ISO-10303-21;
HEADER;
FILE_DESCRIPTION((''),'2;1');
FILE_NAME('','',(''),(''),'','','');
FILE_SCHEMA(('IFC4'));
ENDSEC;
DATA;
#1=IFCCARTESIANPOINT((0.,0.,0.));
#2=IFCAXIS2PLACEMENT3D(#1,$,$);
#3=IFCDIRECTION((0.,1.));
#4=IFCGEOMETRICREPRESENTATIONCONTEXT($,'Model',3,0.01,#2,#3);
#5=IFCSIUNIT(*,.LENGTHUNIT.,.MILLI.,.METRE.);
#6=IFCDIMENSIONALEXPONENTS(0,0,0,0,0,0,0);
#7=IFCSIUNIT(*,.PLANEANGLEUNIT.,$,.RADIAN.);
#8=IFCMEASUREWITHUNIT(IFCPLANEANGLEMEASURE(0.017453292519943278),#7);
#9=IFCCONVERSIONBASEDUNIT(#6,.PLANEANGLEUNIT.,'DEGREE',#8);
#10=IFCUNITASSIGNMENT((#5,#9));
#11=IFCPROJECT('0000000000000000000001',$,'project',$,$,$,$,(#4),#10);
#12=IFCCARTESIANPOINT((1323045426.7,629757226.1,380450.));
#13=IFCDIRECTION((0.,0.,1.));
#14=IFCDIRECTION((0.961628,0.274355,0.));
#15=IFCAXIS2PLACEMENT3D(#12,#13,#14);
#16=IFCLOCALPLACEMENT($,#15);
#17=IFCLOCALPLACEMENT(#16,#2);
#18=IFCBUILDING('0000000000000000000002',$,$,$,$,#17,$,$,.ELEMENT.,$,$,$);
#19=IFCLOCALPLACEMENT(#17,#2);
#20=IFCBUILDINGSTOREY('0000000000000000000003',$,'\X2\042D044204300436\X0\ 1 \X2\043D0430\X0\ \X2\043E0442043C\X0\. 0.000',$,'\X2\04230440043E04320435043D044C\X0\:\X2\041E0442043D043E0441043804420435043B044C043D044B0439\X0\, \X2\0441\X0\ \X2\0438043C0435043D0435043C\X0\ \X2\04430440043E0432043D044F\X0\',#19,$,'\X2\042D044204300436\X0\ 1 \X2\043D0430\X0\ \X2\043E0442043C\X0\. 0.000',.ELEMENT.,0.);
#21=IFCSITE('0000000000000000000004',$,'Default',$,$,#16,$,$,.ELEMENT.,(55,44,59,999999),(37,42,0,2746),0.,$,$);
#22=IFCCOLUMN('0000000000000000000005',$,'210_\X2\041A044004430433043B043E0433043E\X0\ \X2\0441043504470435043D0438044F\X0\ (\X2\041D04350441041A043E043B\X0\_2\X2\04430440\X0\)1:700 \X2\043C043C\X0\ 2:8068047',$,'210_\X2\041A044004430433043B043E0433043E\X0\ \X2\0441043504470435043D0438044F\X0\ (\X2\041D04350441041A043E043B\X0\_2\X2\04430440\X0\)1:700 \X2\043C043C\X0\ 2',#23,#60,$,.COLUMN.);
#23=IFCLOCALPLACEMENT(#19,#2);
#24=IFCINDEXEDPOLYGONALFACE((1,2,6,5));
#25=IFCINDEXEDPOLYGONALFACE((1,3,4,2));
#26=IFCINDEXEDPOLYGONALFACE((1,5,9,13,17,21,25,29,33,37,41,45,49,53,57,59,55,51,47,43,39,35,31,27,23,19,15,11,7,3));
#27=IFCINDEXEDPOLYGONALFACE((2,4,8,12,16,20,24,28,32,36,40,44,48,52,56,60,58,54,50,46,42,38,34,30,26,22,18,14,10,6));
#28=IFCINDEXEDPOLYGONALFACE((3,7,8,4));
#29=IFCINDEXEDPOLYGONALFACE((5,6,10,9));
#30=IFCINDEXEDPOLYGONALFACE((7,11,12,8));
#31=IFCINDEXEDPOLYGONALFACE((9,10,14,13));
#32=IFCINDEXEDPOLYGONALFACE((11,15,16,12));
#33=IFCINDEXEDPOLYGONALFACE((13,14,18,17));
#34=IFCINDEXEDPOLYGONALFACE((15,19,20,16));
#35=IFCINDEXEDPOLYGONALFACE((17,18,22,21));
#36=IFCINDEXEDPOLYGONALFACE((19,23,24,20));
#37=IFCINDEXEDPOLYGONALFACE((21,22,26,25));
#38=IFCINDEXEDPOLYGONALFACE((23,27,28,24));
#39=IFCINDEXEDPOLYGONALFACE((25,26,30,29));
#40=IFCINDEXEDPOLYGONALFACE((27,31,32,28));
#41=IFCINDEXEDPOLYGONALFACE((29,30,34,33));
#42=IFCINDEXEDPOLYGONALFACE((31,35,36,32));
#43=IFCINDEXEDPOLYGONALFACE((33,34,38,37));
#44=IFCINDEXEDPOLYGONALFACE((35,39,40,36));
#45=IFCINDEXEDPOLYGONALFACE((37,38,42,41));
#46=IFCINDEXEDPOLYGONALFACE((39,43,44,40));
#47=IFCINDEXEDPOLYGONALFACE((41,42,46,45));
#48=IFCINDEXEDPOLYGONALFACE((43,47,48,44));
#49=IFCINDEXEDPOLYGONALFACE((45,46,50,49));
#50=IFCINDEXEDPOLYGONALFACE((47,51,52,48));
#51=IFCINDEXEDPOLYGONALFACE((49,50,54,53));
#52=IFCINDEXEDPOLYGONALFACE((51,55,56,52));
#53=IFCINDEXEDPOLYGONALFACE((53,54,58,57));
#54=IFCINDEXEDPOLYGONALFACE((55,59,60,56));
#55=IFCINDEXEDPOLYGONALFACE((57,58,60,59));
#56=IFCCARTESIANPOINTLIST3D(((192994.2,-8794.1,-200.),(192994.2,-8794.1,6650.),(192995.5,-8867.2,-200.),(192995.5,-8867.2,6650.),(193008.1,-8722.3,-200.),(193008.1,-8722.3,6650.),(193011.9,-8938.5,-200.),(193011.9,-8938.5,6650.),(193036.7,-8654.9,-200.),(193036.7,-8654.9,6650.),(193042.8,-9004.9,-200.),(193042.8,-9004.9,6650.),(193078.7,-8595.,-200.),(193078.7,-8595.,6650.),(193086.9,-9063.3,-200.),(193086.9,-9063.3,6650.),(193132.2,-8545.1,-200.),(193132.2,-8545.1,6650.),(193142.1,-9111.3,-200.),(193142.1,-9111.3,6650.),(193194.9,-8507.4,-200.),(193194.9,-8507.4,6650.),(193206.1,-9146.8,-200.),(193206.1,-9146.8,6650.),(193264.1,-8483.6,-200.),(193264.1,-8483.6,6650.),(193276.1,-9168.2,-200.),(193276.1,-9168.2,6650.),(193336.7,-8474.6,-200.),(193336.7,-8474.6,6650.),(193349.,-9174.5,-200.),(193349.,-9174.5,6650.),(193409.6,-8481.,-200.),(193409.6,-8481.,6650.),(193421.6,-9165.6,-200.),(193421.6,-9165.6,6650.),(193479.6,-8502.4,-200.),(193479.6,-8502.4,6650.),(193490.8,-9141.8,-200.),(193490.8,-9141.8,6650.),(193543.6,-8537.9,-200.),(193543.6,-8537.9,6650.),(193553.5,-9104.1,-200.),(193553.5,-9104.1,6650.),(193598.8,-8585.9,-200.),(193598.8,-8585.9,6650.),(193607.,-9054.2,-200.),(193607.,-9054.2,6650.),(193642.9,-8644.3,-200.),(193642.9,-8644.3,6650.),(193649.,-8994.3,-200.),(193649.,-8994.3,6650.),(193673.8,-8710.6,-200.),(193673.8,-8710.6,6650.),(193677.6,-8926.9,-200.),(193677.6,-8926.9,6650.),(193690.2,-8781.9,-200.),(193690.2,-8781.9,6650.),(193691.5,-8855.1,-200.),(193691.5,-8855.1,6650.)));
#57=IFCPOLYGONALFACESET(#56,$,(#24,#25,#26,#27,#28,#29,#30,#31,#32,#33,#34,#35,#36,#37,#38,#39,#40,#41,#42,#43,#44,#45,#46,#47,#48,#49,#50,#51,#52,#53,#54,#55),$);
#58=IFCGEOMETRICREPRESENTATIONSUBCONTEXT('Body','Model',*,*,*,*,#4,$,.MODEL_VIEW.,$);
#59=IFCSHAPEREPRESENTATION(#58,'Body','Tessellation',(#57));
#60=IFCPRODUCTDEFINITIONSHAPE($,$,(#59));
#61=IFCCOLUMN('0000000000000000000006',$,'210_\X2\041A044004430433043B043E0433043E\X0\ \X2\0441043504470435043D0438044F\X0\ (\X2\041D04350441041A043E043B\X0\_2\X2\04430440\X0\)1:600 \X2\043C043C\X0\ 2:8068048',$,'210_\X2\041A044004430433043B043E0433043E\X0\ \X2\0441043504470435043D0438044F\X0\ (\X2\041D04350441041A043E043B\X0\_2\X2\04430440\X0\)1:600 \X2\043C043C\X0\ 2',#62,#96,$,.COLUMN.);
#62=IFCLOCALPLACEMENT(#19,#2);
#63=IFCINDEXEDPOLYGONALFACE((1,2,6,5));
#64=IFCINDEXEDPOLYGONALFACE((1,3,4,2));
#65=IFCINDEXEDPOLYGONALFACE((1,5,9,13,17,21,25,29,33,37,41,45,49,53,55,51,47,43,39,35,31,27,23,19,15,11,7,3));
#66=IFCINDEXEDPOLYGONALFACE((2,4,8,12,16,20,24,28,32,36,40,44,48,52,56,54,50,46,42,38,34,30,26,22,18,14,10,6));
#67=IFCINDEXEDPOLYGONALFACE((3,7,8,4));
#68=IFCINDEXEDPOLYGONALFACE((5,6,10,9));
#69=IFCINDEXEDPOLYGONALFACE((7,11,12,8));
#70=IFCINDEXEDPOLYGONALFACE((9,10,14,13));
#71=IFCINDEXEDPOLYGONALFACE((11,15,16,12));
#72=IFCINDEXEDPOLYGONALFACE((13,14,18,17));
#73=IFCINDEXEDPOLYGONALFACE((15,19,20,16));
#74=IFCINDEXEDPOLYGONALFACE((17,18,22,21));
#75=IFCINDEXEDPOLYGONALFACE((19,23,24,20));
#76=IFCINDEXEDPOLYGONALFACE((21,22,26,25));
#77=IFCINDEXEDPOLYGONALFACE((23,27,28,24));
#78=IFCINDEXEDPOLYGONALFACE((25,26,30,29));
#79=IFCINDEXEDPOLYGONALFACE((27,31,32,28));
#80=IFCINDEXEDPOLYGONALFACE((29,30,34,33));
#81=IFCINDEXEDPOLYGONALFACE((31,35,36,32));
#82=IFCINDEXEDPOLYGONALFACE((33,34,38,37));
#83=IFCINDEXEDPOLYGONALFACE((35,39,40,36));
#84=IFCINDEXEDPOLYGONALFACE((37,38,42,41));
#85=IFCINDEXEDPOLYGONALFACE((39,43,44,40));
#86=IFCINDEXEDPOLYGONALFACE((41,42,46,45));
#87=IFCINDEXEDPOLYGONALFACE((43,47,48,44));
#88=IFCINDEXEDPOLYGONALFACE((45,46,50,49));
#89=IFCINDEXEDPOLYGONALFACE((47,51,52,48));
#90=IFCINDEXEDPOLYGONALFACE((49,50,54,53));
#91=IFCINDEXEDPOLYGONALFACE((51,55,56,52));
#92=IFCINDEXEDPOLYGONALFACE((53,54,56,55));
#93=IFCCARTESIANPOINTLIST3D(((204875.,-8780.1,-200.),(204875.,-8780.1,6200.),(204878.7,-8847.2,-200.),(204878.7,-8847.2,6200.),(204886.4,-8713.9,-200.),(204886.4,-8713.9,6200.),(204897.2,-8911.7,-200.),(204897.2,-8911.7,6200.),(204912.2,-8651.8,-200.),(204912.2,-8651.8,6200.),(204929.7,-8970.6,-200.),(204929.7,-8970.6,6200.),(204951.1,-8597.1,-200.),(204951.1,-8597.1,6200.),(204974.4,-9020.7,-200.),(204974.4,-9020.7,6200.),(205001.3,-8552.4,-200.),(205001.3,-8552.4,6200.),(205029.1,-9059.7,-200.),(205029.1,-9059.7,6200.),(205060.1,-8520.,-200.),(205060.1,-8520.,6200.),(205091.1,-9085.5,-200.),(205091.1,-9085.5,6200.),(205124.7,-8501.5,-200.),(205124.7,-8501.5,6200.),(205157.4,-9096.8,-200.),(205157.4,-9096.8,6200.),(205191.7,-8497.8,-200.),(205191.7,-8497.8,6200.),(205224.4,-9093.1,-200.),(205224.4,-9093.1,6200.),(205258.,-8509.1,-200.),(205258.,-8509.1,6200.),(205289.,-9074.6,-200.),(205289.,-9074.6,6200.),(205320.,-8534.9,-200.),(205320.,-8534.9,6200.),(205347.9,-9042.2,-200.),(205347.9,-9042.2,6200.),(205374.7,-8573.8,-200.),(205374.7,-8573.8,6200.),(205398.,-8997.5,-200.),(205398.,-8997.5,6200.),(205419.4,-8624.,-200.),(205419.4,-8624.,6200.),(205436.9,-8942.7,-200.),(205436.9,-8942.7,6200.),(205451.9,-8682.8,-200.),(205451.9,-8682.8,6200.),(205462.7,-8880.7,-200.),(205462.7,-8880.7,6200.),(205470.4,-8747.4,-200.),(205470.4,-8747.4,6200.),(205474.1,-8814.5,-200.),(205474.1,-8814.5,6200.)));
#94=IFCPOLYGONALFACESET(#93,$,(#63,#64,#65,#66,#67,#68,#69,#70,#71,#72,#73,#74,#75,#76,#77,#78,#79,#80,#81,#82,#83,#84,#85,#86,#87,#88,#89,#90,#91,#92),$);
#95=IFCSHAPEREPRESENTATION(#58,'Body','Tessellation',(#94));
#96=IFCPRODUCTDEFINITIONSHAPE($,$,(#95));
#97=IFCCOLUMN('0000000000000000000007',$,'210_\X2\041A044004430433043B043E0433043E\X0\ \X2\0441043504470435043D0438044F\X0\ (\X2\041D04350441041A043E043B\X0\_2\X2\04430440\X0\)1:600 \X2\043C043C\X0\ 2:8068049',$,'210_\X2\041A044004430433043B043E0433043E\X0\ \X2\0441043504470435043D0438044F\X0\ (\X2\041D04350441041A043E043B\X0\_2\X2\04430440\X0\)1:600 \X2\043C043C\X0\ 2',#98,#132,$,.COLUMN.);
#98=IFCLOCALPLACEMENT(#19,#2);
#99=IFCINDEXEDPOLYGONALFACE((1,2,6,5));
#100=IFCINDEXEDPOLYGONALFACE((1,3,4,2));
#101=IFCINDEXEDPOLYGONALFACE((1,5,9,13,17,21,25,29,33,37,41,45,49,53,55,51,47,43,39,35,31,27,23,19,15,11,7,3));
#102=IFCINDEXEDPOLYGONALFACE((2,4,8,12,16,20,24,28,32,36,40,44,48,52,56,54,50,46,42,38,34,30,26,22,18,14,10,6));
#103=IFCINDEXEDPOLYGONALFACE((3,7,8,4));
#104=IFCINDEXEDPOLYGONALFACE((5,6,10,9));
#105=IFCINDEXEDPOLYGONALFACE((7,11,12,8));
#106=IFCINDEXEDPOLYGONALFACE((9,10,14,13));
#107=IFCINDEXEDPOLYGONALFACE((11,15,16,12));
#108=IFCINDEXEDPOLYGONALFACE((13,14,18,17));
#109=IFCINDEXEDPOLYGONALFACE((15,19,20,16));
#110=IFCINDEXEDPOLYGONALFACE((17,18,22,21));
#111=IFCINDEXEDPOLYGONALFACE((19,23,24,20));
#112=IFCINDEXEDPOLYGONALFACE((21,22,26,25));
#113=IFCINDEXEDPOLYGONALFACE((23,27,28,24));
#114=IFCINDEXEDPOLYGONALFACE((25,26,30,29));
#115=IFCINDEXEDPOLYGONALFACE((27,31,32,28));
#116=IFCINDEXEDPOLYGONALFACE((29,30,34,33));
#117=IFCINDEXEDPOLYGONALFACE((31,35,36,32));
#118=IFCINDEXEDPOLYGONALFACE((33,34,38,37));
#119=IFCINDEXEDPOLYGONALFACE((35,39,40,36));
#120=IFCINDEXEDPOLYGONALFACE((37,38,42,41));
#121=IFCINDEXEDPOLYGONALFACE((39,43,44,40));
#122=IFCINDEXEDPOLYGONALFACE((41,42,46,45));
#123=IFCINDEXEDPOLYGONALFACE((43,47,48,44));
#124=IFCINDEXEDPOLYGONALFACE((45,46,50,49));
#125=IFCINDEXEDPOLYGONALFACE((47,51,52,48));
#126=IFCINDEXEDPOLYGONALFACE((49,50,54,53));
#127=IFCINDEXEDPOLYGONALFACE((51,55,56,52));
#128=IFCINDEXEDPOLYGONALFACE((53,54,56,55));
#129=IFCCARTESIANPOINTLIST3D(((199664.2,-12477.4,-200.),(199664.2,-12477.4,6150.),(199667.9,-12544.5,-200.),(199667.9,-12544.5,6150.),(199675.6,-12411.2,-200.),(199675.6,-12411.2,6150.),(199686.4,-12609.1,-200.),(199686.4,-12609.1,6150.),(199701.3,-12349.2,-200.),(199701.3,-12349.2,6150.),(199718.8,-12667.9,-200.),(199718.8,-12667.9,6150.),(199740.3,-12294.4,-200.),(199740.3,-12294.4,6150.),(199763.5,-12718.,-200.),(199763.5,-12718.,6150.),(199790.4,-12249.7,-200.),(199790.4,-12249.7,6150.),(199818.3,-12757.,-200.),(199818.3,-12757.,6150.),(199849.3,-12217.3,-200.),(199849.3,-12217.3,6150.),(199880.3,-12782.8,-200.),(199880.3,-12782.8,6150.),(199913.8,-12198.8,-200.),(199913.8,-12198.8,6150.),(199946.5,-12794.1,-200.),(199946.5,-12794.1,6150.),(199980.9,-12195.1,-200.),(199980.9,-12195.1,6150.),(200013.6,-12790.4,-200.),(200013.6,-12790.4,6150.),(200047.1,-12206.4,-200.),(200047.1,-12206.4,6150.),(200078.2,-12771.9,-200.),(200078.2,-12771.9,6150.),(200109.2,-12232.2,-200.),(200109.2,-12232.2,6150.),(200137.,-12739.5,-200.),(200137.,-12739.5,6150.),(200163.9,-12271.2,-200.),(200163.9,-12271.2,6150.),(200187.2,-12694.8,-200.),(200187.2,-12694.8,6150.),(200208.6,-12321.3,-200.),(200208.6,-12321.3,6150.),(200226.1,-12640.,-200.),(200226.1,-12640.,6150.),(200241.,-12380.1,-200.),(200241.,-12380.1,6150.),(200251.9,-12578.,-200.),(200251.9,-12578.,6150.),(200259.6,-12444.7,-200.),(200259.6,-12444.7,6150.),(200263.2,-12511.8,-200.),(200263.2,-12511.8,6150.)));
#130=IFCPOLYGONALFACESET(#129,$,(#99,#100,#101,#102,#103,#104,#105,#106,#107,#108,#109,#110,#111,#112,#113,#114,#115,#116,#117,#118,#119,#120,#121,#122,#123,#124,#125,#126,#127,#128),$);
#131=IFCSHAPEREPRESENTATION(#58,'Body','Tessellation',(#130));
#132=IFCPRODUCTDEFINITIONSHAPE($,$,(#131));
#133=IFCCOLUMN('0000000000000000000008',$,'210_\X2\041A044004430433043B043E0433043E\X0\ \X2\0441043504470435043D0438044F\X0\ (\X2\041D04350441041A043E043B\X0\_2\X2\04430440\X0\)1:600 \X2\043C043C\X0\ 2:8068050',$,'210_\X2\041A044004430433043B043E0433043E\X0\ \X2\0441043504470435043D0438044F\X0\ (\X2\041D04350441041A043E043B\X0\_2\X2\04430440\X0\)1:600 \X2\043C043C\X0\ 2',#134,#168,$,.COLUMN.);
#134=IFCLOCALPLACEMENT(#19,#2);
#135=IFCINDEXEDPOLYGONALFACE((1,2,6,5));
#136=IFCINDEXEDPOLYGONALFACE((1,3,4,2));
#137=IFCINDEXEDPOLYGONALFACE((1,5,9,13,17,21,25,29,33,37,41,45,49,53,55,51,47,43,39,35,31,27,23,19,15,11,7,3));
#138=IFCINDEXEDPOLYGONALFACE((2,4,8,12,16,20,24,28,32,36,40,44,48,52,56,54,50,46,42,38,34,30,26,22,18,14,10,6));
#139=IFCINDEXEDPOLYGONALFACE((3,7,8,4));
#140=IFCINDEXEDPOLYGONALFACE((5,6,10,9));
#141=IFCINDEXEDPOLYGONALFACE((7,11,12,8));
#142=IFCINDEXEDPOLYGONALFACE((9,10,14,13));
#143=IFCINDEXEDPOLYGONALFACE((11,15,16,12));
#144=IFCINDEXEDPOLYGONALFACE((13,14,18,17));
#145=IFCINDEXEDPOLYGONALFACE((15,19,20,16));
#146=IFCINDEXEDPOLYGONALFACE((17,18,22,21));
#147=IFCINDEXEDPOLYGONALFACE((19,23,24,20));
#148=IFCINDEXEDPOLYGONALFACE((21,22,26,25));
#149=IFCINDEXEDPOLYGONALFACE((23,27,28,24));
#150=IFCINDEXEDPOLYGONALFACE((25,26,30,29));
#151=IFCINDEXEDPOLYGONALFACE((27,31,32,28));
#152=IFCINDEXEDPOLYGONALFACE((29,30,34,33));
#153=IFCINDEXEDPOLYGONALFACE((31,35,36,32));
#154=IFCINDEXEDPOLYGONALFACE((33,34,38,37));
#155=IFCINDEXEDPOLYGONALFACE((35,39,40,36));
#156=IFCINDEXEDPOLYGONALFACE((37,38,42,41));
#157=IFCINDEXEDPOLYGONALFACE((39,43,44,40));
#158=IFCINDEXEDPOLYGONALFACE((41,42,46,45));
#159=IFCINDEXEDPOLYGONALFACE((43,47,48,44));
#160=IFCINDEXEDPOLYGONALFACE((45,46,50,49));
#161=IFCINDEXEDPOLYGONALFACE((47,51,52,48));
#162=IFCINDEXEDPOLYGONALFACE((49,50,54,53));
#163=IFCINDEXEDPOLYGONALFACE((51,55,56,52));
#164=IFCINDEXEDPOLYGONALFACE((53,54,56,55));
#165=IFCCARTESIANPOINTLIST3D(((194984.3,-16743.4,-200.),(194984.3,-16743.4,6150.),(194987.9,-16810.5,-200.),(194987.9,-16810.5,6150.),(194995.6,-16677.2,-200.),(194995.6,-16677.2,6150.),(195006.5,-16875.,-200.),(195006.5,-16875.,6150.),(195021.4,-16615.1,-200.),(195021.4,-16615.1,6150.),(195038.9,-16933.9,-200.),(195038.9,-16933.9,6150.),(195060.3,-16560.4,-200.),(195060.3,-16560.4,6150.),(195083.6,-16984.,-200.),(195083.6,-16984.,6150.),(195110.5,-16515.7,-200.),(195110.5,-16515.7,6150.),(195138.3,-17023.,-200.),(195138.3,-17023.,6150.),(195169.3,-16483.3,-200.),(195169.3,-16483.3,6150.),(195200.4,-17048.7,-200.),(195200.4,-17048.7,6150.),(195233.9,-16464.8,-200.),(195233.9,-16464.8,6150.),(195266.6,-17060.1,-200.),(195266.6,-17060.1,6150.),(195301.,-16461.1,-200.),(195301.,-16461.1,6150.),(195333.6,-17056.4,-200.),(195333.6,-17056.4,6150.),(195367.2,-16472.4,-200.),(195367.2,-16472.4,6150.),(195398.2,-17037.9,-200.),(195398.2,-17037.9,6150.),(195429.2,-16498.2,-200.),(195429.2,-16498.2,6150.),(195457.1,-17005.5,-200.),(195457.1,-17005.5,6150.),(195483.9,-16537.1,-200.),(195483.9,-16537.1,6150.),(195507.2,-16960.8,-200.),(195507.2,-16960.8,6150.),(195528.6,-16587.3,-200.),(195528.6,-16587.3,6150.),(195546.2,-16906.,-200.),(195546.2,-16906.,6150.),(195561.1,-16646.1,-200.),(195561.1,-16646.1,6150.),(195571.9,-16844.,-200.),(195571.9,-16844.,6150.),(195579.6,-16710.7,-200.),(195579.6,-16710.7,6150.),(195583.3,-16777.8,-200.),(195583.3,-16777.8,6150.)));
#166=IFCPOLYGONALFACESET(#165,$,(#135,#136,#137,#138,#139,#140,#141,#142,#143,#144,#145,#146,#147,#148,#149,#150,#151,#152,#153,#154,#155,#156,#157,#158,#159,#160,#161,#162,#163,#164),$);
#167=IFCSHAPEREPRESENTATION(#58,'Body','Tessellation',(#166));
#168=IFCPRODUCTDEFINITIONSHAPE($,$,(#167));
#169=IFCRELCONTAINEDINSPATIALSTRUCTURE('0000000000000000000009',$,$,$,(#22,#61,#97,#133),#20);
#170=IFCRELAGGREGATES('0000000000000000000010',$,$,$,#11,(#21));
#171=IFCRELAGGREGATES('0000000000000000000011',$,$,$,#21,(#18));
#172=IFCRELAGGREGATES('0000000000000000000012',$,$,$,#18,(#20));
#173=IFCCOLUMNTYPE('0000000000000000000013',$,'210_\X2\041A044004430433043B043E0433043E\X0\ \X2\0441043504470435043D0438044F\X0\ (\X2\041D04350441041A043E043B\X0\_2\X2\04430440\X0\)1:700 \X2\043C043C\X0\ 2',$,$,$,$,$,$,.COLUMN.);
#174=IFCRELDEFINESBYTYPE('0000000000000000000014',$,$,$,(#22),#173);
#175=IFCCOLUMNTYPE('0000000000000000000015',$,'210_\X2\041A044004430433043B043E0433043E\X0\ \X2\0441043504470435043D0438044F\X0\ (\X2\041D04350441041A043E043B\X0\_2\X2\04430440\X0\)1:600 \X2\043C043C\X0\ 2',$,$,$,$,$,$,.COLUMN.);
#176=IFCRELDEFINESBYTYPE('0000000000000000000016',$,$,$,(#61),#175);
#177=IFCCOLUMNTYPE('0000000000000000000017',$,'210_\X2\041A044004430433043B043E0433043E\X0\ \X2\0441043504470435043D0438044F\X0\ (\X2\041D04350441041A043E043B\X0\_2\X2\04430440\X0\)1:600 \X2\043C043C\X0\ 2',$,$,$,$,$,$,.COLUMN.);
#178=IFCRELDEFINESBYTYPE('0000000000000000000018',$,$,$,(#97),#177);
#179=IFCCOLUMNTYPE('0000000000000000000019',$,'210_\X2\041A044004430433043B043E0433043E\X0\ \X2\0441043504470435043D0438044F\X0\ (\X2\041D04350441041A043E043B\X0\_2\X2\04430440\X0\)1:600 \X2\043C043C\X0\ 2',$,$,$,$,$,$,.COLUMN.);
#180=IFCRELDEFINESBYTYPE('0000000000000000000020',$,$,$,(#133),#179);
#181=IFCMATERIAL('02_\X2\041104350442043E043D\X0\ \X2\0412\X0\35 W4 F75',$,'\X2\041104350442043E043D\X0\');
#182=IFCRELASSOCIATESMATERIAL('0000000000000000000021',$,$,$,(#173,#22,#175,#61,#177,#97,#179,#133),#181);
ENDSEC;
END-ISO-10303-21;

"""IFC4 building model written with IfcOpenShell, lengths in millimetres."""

from ifc_helpers import new_model, entity, si_unit, converted_unit, direction, frame, origin, place, context, subcontext, project, spatial, arc, indexed_curve, outline, extrude, source, transform, mapped, material, type_object, type_shapes, element, save


model = new_model("IFC4")

# Units and contexts
model_context = context("Model", 3, precision=0.01, world=origin(), true_north=direction((0.0, 1.0)))
body_context = subcontext(model_context, "Body", "Model", "MODEL_VIEW")
ifc_project = project(units=[si_unit("LENGTHUNIT", "METRE", prefix="MILLI"), converted_unit("PLANEANGLEUNIT", "DEGREE", entity("IfcPlaneAngleMeasure", 0.017453292519943278), si_unit("PLANEANGLEUNIT", "RADIAN"), dimensions=[0, 0, 0, 0, 0, 0, 0])], contexts=[model_context])

# Site, building, storey
site_placement = place(None, frame((1323045426.7, 629757226.1, 380450.0), z_axis=(0.0, 0.0, 1.0), x_axis=(0.961628, 0.274355, 0.0)))
site = spatial("IfcSite", under=ifc_project, at=site_placement, Name="Default", CompositionType="ELEMENT", RefLatitude=(55, 44, 59, 999999), RefLongitude=(37, 42, 0, 2746), RefElevation=0.0)
building_placement = place(site_placement, origin())
building = spatial("IfcBuilding", under=site, at=building_placement, CompositionType="ELEMENT")
storey_placement = place(building_placement, origin())
storey = spatial("IfcBuildingStorey", under=building, at=storey_placement, Name="Этаж 1 на отм. 0.000", ObjectType="Уровень:Относительный, с именем уровня", LongName="Этаж 1 на отм. 0.000", CompositionType="ELEMENT", Elevation=0.0)

# Columns
ifc_material = material(Name="02_Бетон В35 W4 F75", Category="Бетон")
column_type_1 = type_object("IfcColumnType", Name="210_Круглого сечения (НесКол_2ур)1:700 мм 2", PredefinedType="COLUMN", material=ifc_material)
shared_shape_1 = source(origin(), body_context, "Body", "SweptSolid", [
    extrude(outline(indexed_curve([(-350.0, 0.0), (0.0, -350.0), (350.0, 0.0), (0.0, 350.0)], segments=[arc(1, 2, 3), arc(3, 4, 1)], self_intersect=False)), frame((193342.9, -8824.6, -200.0), z_axis=(0.0, 0.0, 1.0), x_axis=(0.87462, -0.48481, 0.0)), (0.0, 0.0, 1.0), 6850.0),
])
type_shapes(column_type_1, [shared_shape_1])
column_1_placement = place(storey_placement, origin())
element("IfcColumn", 1, at=column_1_placement, inside=storey, type_object=column_type_1, material=ifc_material, Name="210_Круглого сечения (НесКол_2ур)1:700 мм 2:8068047", ObjectType="210_Круглого сечения (НесКол_2ур)1:700 мм 2", PredefinedType="COLUMN", context=body_context, shape_type="MappedRepresentation", body=[
    mapped(shared_shape_1, transform((0.0, 0.0, 0.0), scale=1.0)),
])
column_type_2 = type_object("IfcColumnType", Name="210_Круглого сечения (НесКол_2ур)1:600 мм 2", PredefinedType="COLUMN", material=ifc_material)
shared_shape_2 = source(origin(), body_context, "Body", "SweptSolid", [
    extrude(outline(indexed_curve([(-300.0, 0.0), (0.0, -300.0), (300.0, 0.0), (0.0, 300.0)], segments=[arc(1, 2, 3), arc(3, 4, 1)], self_intersect=False)), frame((205174.6, -8797.3, -200.0), z_axis=(0.0, 0.0, 1.0), x_axis=(0.87462, -0.48481, 0.0)), (0.0, 0.0, 1.0), 6400.0),
])
type_shapes(column_type_2, [shared_shape_2])
column_2_placement = place(storey_placement, origin())
element("IfcColumn", 2, at=column_2_placement, inside=storey, type_object=column_type_2, material=ifc_material, Name="210_Круглого сечения (НесКол_2ур)1:600 мм 2:8068048", ObjectType="210_Круглого сечения (НесКол_2ур)1:600 мм 2", PredefinedType="COLUMN", context=body_context, shape_type="MappedRepresentation", body=[
    mapped(shared_shape_2, transform((0.0, 0.0, 0.0), scale=1.0)),
])
column_type_3 = type_object("IfcColumnType", Name="210_Круглого сечения (НесКол_2ур)1:600 мм 2", PredefinedType="COLUMN", material=ifc_material)
shared_shape_3 = source(origin(), body_context, "Body", "SweptSolid", [
    extrude(outline(indexed_curve([(-300.0, 0.0), (0.0, -300.0), (300.0, 0.0), (0.0, 300.0)], segments=[arc(1, 2, 3), arc(3, 4, 1)], self_intersect=False)), frame((199963.7, -12494.6, -200.0), z_axis=(0.0, 0.0, 1.0), x_axis=(0.87462, -0.48481, 0.0)), (0.0, 0.0, 1.0), 6350.0),
])
type_shapes(column_type_3, [shared_shape_3])
column_3_placement = place(storey_placement, origin())
element("IfcColumn", 3, at=column_3_placement, inside=storey, type_object=column_type_3, material=ifc_material, Name="210_Круглого сечения (НесКол_2ур)1:600 мм 2:8068049", ObjectType="210_Круглого сечения (НесКол_2ур)1:600 мм 2", PredefinedType="COLUMN", context=body_context, shape_type="MappedRepresentation", body=[
    mapped(shared_shape_3, transform((0.0, 0.0, 0.0), scale=1.0)),
])
column_type_4 = type_object("IfcColumnType", Name="210_Круглого сечения (НесКол_2ур)1:600 мм 2", PredefinedType="COLUMN", material=ifc_material)
shared_shape_4 = source(origin(), body_context, "Body", "SweptSolid", [
    extrude(outline(indexed_curve([(-300.0, 0.0), (0.0, -300.0), (300.0, 0.0), (0.0, 300.0)], segments=[arc(1, 2, 3), arc(3, 4, 1)], self_intersect=False)), frame((195283.8, -16760.6, -200.0), z_axis=(0.0, 0.0, 1.0), x_axis=(0.48481, 0.87462, 0.0)), (0.0, 0.0, 1.0), 6350.0),
])
type_shapes(column_type_4, [shared_shape_4])
column_4_placement = place(storey_placement, origin())
element("IfcColumn", 4, at=column_4_placement, inside=storey, type_object=column_type_4, material=ifc_material, Name="210_Круглого сечения (НесКол_2ур)1:600 мм 2:8068050", ObjectType="210_Круглого сечения (НесКол_2ур)1:600 мм 2", PredefinedType="COLUMN", context=body_context, shape_type="MappedRepresentation", body=[
    mapped(shared_shape_4, transform((0.0, 0.0, 0.0), scale=1.0)),
])

save(model, "model.ifc")
